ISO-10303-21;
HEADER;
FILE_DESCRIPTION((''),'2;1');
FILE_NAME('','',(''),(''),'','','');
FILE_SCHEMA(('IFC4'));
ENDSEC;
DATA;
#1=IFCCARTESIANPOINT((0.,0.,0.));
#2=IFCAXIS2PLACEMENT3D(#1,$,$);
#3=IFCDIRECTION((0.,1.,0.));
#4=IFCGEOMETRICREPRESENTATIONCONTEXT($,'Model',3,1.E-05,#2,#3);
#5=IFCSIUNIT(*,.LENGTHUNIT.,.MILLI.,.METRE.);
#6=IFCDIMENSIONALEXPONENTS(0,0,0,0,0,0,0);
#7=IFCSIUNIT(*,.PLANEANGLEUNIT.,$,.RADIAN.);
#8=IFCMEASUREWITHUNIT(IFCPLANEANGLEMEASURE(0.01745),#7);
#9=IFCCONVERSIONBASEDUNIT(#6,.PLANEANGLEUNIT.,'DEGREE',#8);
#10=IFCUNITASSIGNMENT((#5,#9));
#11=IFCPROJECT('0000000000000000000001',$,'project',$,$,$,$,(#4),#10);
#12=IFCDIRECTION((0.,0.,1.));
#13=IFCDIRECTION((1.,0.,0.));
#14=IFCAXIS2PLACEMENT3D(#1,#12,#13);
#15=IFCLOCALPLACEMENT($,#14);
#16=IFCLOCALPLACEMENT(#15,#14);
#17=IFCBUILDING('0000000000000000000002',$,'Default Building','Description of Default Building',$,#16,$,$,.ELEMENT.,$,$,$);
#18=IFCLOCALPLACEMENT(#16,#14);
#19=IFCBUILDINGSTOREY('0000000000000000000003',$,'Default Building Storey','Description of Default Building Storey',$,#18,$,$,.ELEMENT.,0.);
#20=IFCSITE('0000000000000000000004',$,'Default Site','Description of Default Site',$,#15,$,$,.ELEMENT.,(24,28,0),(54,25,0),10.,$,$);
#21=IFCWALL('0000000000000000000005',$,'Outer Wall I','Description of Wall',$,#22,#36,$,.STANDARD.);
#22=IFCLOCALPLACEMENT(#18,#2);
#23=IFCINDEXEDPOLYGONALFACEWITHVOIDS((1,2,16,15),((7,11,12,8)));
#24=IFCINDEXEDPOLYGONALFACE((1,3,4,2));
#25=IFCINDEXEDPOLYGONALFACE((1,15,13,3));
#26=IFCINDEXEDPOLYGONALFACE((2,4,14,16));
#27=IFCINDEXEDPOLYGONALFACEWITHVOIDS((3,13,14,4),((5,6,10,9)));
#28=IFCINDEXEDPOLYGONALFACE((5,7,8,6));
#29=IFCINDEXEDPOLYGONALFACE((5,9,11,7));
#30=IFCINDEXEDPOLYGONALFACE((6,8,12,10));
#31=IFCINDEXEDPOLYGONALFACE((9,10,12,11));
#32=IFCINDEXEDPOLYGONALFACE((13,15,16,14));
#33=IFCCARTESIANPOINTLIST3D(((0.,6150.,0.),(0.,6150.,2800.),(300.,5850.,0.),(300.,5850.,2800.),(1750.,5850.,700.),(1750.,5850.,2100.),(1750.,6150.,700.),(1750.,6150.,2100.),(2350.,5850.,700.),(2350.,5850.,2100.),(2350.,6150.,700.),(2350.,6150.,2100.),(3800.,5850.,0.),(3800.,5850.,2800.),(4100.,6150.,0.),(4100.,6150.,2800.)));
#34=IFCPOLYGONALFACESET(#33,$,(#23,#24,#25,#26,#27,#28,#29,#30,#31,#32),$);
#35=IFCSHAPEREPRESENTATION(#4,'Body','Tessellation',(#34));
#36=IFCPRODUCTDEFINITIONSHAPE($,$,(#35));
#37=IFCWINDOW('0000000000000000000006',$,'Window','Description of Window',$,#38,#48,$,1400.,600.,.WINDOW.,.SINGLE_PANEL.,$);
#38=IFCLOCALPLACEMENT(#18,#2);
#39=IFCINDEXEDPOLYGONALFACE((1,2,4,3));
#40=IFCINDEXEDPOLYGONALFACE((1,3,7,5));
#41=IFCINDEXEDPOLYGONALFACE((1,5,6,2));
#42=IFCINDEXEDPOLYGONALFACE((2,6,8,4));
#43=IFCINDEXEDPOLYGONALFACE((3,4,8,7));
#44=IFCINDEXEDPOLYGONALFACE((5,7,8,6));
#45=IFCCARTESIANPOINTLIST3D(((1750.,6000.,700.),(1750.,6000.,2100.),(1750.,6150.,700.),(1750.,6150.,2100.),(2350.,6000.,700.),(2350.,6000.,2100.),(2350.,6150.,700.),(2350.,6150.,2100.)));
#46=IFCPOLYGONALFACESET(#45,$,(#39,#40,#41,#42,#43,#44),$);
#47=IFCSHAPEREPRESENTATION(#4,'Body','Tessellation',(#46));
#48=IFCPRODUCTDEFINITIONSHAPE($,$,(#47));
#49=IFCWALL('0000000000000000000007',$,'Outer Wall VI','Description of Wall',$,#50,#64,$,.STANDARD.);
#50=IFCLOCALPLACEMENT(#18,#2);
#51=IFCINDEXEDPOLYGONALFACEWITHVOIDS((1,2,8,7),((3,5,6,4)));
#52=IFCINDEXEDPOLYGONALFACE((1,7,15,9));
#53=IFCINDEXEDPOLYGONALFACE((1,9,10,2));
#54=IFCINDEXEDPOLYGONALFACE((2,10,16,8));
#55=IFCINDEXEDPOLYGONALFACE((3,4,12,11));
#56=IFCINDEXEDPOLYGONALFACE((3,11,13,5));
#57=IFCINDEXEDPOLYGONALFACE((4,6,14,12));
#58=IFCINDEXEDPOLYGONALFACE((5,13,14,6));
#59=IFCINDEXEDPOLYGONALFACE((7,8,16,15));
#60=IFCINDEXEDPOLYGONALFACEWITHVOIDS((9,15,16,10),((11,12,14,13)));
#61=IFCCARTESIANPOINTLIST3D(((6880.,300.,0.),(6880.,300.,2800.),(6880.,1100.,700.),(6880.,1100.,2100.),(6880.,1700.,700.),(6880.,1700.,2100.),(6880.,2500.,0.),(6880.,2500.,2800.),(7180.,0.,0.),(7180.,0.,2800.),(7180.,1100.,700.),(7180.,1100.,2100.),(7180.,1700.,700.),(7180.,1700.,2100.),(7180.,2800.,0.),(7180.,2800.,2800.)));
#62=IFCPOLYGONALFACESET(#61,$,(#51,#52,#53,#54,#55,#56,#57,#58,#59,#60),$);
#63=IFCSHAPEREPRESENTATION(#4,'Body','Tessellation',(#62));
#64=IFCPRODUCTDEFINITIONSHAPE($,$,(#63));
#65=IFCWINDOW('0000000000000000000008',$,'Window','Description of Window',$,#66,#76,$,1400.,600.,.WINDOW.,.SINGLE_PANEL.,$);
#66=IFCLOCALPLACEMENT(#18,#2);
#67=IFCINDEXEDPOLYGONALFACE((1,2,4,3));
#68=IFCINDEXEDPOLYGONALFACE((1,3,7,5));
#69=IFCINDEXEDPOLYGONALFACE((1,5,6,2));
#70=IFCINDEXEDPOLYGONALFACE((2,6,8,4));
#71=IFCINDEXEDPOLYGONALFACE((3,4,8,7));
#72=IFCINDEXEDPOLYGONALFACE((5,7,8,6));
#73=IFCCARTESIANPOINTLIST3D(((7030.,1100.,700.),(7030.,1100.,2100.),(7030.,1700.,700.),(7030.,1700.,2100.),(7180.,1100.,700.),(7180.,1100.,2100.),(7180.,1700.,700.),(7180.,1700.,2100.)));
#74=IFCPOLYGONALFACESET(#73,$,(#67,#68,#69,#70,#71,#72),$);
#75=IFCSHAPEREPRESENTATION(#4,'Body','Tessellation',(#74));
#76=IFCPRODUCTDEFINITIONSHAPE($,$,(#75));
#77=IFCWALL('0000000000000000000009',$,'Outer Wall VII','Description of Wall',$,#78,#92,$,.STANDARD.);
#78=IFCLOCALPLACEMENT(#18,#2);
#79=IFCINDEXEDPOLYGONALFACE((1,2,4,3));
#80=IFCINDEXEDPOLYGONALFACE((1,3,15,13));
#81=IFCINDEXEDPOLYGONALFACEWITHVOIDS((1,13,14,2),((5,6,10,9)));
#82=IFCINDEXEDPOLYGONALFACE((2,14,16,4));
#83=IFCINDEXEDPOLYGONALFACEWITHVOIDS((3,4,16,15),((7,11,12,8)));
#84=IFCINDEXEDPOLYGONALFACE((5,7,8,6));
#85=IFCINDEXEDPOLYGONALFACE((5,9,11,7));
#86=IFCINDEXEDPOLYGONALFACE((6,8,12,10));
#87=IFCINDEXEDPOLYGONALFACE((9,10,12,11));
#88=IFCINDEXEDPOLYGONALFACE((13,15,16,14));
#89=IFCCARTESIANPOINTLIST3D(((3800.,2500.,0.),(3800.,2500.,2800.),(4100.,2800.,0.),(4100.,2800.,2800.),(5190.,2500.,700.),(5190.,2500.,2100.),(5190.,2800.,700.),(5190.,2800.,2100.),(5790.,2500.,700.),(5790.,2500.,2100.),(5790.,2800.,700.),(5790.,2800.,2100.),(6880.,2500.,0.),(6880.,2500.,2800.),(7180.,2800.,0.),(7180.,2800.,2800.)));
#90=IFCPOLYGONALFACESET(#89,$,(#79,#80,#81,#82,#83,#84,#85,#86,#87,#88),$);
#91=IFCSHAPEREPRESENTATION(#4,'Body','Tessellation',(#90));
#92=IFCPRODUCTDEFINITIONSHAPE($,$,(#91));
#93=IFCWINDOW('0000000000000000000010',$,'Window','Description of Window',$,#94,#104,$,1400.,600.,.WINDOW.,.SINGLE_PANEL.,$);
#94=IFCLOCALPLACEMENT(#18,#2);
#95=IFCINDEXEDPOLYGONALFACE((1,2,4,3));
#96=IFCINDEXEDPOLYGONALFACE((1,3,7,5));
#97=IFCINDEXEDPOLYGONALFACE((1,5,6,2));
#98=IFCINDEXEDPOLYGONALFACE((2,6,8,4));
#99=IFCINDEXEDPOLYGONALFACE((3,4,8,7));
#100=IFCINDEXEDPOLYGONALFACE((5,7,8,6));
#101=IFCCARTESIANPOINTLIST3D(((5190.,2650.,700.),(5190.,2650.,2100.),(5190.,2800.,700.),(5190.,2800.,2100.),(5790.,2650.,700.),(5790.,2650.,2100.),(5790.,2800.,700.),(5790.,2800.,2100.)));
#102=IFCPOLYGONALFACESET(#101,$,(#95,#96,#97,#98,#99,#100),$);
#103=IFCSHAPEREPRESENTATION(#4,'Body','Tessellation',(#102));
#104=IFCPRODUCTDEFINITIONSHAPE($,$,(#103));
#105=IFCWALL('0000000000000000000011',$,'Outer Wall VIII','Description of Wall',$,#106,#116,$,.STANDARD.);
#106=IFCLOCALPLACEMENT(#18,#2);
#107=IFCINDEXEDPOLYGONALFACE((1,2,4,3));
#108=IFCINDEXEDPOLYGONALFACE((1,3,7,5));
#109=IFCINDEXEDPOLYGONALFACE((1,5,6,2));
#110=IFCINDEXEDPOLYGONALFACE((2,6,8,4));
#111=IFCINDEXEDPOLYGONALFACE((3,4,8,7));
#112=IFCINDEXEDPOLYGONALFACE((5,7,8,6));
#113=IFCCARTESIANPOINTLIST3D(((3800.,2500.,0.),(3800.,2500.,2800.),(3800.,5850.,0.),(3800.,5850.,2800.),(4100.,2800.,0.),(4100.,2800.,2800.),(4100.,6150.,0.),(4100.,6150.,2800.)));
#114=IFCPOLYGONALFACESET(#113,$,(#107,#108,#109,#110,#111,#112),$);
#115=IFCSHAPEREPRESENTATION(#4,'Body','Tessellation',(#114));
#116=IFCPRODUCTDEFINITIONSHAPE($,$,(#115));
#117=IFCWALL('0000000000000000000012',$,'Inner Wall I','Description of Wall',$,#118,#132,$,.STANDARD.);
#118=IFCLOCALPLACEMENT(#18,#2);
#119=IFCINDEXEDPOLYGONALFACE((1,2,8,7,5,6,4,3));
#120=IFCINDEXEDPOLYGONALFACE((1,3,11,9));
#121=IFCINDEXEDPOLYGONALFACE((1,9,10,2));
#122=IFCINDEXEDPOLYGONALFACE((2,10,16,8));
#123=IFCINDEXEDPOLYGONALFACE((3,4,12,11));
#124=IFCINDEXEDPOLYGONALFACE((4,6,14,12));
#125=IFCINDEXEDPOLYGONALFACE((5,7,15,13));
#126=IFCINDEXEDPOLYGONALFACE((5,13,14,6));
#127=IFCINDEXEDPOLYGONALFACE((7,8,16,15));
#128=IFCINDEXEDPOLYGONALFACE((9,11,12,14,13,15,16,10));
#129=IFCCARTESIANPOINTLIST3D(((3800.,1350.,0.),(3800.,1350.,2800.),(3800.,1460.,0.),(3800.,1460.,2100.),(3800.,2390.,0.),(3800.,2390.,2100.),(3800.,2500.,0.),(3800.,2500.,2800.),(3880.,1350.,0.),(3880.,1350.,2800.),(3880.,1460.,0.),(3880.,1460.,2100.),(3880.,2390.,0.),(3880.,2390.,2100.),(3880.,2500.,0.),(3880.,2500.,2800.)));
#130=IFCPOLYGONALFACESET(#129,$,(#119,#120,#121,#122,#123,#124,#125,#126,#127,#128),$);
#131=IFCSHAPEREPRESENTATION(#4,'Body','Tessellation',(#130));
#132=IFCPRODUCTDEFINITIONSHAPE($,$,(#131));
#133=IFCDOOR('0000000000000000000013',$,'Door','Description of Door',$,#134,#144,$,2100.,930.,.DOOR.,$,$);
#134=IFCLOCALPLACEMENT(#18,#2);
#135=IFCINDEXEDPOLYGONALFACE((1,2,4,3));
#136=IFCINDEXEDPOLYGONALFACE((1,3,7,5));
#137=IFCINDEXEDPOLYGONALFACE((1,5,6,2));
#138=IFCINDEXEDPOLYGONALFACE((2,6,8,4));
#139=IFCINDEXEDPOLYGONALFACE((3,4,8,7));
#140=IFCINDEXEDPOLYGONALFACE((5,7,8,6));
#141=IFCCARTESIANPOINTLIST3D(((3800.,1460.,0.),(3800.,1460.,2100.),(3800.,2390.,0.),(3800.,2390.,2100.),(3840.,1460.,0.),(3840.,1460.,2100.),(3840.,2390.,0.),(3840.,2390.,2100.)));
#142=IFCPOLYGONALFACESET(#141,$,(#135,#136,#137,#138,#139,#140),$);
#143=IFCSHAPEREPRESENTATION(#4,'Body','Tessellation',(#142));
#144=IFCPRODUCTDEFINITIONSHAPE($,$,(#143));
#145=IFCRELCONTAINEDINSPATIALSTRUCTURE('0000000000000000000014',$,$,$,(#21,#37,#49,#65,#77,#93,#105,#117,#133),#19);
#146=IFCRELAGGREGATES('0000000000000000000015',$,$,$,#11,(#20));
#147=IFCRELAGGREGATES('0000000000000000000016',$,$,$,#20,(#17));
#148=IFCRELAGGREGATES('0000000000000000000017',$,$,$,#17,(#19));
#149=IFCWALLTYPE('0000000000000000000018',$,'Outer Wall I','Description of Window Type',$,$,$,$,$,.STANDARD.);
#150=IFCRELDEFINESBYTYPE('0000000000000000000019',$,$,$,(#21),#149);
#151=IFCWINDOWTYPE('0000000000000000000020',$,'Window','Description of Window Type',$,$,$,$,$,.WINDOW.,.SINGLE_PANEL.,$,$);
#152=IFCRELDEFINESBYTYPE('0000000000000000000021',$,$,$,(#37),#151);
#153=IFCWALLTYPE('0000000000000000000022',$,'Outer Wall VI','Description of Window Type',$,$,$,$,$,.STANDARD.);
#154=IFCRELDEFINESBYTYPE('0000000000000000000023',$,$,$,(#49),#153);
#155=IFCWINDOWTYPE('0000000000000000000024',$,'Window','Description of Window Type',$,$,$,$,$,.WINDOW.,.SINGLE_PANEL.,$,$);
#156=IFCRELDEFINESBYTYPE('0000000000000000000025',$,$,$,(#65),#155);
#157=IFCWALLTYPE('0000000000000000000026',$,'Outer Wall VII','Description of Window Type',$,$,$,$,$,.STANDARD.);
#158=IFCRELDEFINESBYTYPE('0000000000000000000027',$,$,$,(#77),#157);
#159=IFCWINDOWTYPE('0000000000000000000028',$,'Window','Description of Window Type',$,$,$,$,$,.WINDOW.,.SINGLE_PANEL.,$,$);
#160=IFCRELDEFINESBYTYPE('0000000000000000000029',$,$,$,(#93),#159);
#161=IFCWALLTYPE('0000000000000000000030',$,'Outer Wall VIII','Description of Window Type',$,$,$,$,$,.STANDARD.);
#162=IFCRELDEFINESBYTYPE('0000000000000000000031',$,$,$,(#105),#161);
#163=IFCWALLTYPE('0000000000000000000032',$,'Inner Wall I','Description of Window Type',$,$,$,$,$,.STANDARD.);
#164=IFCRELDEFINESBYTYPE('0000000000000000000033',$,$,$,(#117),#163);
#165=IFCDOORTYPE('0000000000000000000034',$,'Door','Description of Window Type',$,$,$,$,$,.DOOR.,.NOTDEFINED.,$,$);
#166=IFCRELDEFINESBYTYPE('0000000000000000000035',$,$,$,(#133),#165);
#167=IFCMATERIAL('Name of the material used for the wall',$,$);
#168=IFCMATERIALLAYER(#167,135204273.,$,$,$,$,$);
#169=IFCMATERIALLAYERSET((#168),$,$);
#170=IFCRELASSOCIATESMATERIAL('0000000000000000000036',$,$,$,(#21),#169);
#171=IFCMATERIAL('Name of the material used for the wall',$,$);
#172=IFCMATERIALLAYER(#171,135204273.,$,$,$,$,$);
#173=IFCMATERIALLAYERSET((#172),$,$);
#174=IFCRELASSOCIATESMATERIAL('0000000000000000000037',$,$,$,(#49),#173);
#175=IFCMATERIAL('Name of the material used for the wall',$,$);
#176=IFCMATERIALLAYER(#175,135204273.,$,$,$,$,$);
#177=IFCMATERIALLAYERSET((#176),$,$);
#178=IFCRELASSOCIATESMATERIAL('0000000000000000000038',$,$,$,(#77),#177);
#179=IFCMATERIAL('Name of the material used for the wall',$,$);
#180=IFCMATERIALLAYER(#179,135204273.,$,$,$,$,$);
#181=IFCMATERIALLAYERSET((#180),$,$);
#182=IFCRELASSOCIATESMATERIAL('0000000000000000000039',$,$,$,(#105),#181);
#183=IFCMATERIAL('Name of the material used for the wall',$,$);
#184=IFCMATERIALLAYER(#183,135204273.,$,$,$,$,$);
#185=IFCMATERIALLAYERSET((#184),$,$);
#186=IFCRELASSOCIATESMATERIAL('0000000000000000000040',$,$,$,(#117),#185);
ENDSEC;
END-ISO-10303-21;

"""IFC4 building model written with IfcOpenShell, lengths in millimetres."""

from ifc_helpers import new_model, entity, si_unit, converted_unit, direction, frame, origin, origin_with_axes, place, context, project, spatial, polyline, outline, extrude, material, layer, layer_set, layer_usage, type_object, element, fill, save


model = new_model("IFC4")

# Units and contexts
model_context = context("Model", 3, precision=1e-05, world=origin(), true_north=direction((0.0, 1.0, 0.0)))
ifc_project = project(units=[si_unit("LENGTHUNIT", "METRE", prefix="MILLI"), converted_unit("PLANEANGLEUNIT", "DEGREE", entity("IfcPlaneAngleMeasure", 0.01745), si_unit("PLANEANGLEUNIT", "RADIAN"), dimensions=[0, 0, 0, 0, 0, 0, 0])], contexts=[model_context])

# Site, building, storey
site_placement = place(None, origin_with_axes())
site = spatial("IfcSite", under=ifc_project, at=site_placement, Name="Default Site", Description="Description of Default Site", CompositionType="ELEMENT", RefLatitude=(24, 28, 0), RefLongitude=(54, 25, 0), RefElevation=10.0)
building_placement = place(site_placement, origin_with_axes())
building = spatial("IfcBuilding", under=site, at=building_placement, Name="Default Building", Description="Description of Default Building", CompositionType="ELEMENT")
storey_placement = place(building_placement, origin_with_axes())
storey = spatial("IfcBuildingStorey", under=building, at=storey_placement, Name="Default Building Storey", Description="Description of Default Building Storey", CompositionType="ELEMENT", Elevation=0.0)

# Walls, openings, windows
ifc_material_1 = material(Name="Name of the material used for the wall")
ifc_layer_1 = layer(ifc_material_1, 135204273.0)
ifc_layer_set_1 = layer_set([ifc_layer_1])
ifc_layer_usage_1 = layer_usage(ifc_layer_set_1, "AXIS2", "POSITIVE", -67602136.5)
wall_type_1 = type_object("IfcWallType", Name="Outer Wall I", Description="Description of Window Type", PredefinedType="STANDARD")
wall_1_placement = place(storey_placement, frame((3950.0, 6000.0, 0.0), z_axis=(0.0, 0.0, 1.0), x_axis=(-1.0, 0.0, 0.0)))
wall_1 = element("IfcWall", 1, at=wall_1_placement, inside=storey, type_object=wall_type_1, material=ifc_layer_usage_1, Name="Outer Wall I", Description="Description of Wall", PredefinedType="STANDARD", context=model_context, shape_type="SweptSolid", body=[
    extrude(outline(polyline([(-150.0, -150.0), (150.0, 150.0), (3650.0, 150.0), (3950.0, -150.0), (-150.0, -150.0)])), origin_with_axes(), (0.0, 0.0, 1.0), 2800.0),
])
opening_1_placement = place(wall_1_placement, frame((1600.0, -150.0, 700.0), z_axis=(0.0, 0.0, 1.0), x_axis=(1.0, 0.0, 0.0)))
opening_1 = element("IfcOpeningElement", 2, at=opening_1_placement, cuts=wall_1, context=model_context, shape_type="SweptSolid", body=[
    extrude(outline(polyline([(0.0, 0.0), (0.0, 300.0), (600.0, 300.0), (600.0, 0.0), (0.0, 0.0)])), origin_with_axes(), (0.0, 0.0, 1.0), 1400.0),
])
window_type_1 = type_object("IfcWindowType", Name="Window", Description="Description of Window Type", PartitioningType="SINGLE_PANEL", PredefinedType="WINDOW")
window_1_placement = place(opening_1_placement, origin_with_axes())
window_1 = element("IfcWindow", 3, at=window_1_placement, inside=storey, type_object=window_type_1, Name="Window", Description="Description of Window", OverallHeight=1400.0, OverallWidth=600.0, PartitioningType="SINGLE_PANEL", PredefinedType="WINDOW", context=model_context, shape_type="SweptSolid", body=[
    extrude(outline(polyline([(0.0, 0.0), (0.0, 150.0), (600.0, 150.0), (600.0, 0.0), (0.0, 0.0)])), origin_with_axes(), (0.0, 0.0, 1.0), 1400.0),
])
fill(opening_1, window_1)
ifc_material_2 = material(Name="Name of the material used for the wall")
ifc_layer_2 = layer(ifc_material_2, 135204273.0)
ifc_layer_set_2 = layer_set([ifc_layer_2])
ifc_layer_usage_2 = layer_usage(ifc_layer_set_2, "AXIS2", "POSITIVE", -67602136.5)
wall_type_2 = type_object("IfcWallType", Name="Outer Wall VI", Description="Description of Window Type", PredefinedType="STANDARD")
wall_2_placement = place(storey_placement, frame((7030.0, 150.0, 0.0), z_axis=(0.0, 0.0, 1.0), x_axis=(0.0, 1.0, 0.0)))
wall_2 = element("IfcWall", 4, at=wall_2_placement, inside=storey, type_object=wall_type_2, material=ifc_layer_usage_2, Name="Outer Wall VI", Description="Description of Wall", PredefinedType="STANDARD", context=model_context, shape_type="SweptSolid", body=[
    extrude(outline(polyline([(-150.0, -150.0), (150.0, 150.0), (2350.0, 150.0), (2650.0, -150.0), (-150.0, -150.0)])), origin_with_axes(), (0.0, 0.0, 1.0), 2800.0),
])
opening_2_placement = place(wall_2_placement, frame((950.0, -150.0, 700.0), z_axis=(0.0, 0.0, 1.0), x_axis=(1.0, 0.0, 0.0)))
opening_2 = element("IfcOpeningElement", 5, at=opening_2_placement, cuts=wall_2, context=model_context, shape_type="SweptSolid", body=[
    extrude(outline(polyline([(0.0, 0.0), (0.0, 300.0), (600.0, 300.0), (600.0, 0.0), (0.0, 0.0)])), origin_with_axes(), (0.0, 0.0, 1.0), 1400.0),
])
window_type_2 = type_object("IfcWindowType", Name="Window", Description="Description of Window Type", PartitioningType="SINGLE_PANEL", PredefinedType="WINDOW")
window_2_placement = place(opening_2_placement, origin_with_axes())
window_2 = element("IfcWindow", 6, at=window_2_placement, inside=storey, type_object=window_type_2, Name="Window", Description="Description of Window", OverallHeight=1400.0, OverallWidth=600.0, PartitioningType="SINGLE_PANEL", PredefinedType="WINDOW", context=model_context, shape_type="SweptSolid", body=[
    extrude(outline(polyline([(0.0, 0.0), (0.0, 150.0), (600.0, 150.0), (600.0, 0.0), (0.0, 0.0)])), origin_with_axes(), (0.0, 0.0, 1.0), 1400.0),
])
fill(opening_2, window_2)
ifc_material_3 = material(Name="Name of the material used for the wall")
ifc_layer_3 = layer(ifc_material_3, 135204273.0)
ifc_layer_set_3 = layer_set([ifc_layer_3])
ifc_layer_usage_3 = layer_usage(ifc_layer_set_3, "AXIS2", "POSITIVE", -67602136.5)
wall_type_3 = type_object("IfcWallType", Name="Outer Wall VII", Description="Description of Window Type", PredefinedType="STANDARD")
wall_3_placement = place(storey_placement, frame((7030.0, 2650.0, 0.0), z_axis=(0.0, 0.0, 1.0), x_axis=(-1.0, 0.0, 0.0)))
wall_3 = element("IfcWall", 7, at=wall_3_placement, inside=storey, type_object=wall_type_3, material=ifc_layer_usage_3, Name="Outer Wall VII", Description="Description of Wall", PredefinedType="STANDARD", context=model_context, shape_type="SweptSolid", body=[
    extrude(outline(polyline([(-150.0, -150.0), (150.0, 150.0), (3230.0, 150.0), (2930.0, -150.0), (-150.0, -150.0)])), origin_with_axes(), (0.0, 0.0, 1.0), 2800.0),
])
opening_3_placement = place(wall_3_placement, frame((1240.0, -150.0, 700.0), z_axis=(0.0, 0.0, 1.0), x_axis=(1.0, 0.0, 0.0)))
opening_3 = element("IfcOpeningElement", 8, at=opening_3_placement, cuts=wall_3, context=model_context, shape_type="SweptSolid", body=[
    extrude(outline(polyline([(0.0, 0.0), (0.0, 300.0), (600.0, 300.0), (600.0, 0.0), (0.0, 0.0)])), origin_with_axes(), (0.0, 0.0, 1.0), 1400.0),
])
window_type_3 = type_object("IfcWindowType", Name="Window", Description="Description of Window Type", PartitioningType="SINGLE_PANEL", PredefinedType="WINDOW")
window_3_placement = place(opening_3_placement, origin_with_axes())
window_3 = element("IfcWindow", 9, at=window_3_placement, inside=storey, type_object=window_type_3, Name="Window", Description="Description of Window", OverallHeight=1400.0, OverallWidth=600.0, PartitioningType="SINGLE_PANEL", PredefinedType="WINDOW", context=model_context, shape_type="SweptSolid", body=[
    extrude(outline(polyline([(0.0, 0.0), (0.0, 150.0), (600.0, 150.0), (600.0, 0.0), (0.0, 0.0)])), origin_with_axes(), (0.0, 0.0, 1.0), 1400.0),
])
fill(opening_3, window_3)

# Wall
ifc_material_4 = material(Name="Name of the material used for the wall")
ifc_layer_4 = layer(ifc_material_4, 135204273.0)
ifc_layer_set_4 = layer_set([ifc_layer_4])
ifc_layer_usage_4 = layer_usage(ifc_layer_set_4, "AXIS2", "POSITIVE", -67602136.5)
wall_type_4 = type_object("IfcWallType", Name="Outer Wall VIII", Description="Description of Window Type", PredefinedType="STANDARD")
wall_4_placement = place(storey_placement, frame((3950.0, 2650.0, 0.0), z_axis=(0.0, 0.0, 1.0), x_axis=(0.0, 1.0, 0.0)))
element("IfcWall", 10, at=wall_4_placement, inside=storey, type_object=wall_type_4, material=ifc_layer_usage_4, Name="Outer Wall VIII", Description="Description of Wall", PredefinedType="STANDARD", context=model_context, shape_type="SweptSolid", body=[
    extrude(outline(polyline([(150.0, -150.0), (-150.0, 150.0), (3200.0, 150.0), (3500.0, -150.0), (150.0, -150.0)])), origin_with_axes(), (0.0, 0.0, 1.0), 2800.0),
])

# Wall, opening, door
ifc_material_5 = material(Name="Name of the material used for the wall")
ifc_layer_5 = layer(ifc_material_5, 135204273.0)
ifc_layer_set_5 = layer_set([ifc_layer_5])
ifc_layer_usage_5 = layer_usage(ifc_layer_set_5, "AXIS2", "POSITIVE", -67602136.5)
wall_type_5 = type_object("IfcWallType", Name="Inner Wall I", Description="Description of Window Type", PredefinedType="STANDARD")
wall_5_placement = place(storey_placement, frame((3840.0, 2500.0, 0.0), z_axis=(0.0, 0.0, 1.0), x_axis=(0.0, -1.0, 0.0)))
wall_5 = element("IfcWall", 11, at=wall_5_placement, inside=storey, type_object=wall_type_5, material=ifc_layer_usage_5, Name="Inner Wall I", Description="Description of Wall", PredefinedType="STANDARD", context=model_context, shape_type="SweptSolid", body=[
    extrude(outline(polyline([(0.0, -40.0), (0.0, 40.0), (1150.0, 40.0), (1150.0, -40.0), (0.0, -40.0)])), origin_with_axes(), (0.0, 0.0, 1.0), 2800.0),
])
opening_4_placement = place(wall_5_placement, frame((110.0, -40.0, 0.0), z_axis=(0.0, 0.0, 1.0), x_axis=(1.0, 0.0, 0.0)))
opening_4 = element("IfcOpeningElement", 12, at=opening_4_placement, cuts=wall_5, context=model_context, shape_type="SweptSolid", body=[
    extrude(outline(polyline([(0.0, 0.0), (0.0, 80.0), (930.0, 80.0), (930.0, 0.0), (0.0, 0.0)])), origin_with_axes(), (0.0, 0.0, 1.0), 2100.0),
])
door_type_1 = type_object("IfcDoorType", Name="Door", Description="Description of Window Type", PredefinedType="DOOR")
door_1_placement = place(opening_4_placement, origin_with_axes())
door_1 = element("IfcDoor", 13, at=door_1_placement, inside=storey, type_object=door_type_1, Name="Door", Description="Description of Door", OverallHeight=2100.0, OverallWidth=930.0, PredefinedType="DOOR", context=model_context, shape_type="SweptSolid", body=[
    extrude(outline(polyline([(0.0, 0.0), (0.0, 40.0), (930.0, 40.0), (930.0, 0.0), (0.0, 0.0)])), origin_with_axes(), (0.0, 0.0, 1.0), 2100.0),
])
fill(opening_4, door_1)

save(model, "model.ifc")
